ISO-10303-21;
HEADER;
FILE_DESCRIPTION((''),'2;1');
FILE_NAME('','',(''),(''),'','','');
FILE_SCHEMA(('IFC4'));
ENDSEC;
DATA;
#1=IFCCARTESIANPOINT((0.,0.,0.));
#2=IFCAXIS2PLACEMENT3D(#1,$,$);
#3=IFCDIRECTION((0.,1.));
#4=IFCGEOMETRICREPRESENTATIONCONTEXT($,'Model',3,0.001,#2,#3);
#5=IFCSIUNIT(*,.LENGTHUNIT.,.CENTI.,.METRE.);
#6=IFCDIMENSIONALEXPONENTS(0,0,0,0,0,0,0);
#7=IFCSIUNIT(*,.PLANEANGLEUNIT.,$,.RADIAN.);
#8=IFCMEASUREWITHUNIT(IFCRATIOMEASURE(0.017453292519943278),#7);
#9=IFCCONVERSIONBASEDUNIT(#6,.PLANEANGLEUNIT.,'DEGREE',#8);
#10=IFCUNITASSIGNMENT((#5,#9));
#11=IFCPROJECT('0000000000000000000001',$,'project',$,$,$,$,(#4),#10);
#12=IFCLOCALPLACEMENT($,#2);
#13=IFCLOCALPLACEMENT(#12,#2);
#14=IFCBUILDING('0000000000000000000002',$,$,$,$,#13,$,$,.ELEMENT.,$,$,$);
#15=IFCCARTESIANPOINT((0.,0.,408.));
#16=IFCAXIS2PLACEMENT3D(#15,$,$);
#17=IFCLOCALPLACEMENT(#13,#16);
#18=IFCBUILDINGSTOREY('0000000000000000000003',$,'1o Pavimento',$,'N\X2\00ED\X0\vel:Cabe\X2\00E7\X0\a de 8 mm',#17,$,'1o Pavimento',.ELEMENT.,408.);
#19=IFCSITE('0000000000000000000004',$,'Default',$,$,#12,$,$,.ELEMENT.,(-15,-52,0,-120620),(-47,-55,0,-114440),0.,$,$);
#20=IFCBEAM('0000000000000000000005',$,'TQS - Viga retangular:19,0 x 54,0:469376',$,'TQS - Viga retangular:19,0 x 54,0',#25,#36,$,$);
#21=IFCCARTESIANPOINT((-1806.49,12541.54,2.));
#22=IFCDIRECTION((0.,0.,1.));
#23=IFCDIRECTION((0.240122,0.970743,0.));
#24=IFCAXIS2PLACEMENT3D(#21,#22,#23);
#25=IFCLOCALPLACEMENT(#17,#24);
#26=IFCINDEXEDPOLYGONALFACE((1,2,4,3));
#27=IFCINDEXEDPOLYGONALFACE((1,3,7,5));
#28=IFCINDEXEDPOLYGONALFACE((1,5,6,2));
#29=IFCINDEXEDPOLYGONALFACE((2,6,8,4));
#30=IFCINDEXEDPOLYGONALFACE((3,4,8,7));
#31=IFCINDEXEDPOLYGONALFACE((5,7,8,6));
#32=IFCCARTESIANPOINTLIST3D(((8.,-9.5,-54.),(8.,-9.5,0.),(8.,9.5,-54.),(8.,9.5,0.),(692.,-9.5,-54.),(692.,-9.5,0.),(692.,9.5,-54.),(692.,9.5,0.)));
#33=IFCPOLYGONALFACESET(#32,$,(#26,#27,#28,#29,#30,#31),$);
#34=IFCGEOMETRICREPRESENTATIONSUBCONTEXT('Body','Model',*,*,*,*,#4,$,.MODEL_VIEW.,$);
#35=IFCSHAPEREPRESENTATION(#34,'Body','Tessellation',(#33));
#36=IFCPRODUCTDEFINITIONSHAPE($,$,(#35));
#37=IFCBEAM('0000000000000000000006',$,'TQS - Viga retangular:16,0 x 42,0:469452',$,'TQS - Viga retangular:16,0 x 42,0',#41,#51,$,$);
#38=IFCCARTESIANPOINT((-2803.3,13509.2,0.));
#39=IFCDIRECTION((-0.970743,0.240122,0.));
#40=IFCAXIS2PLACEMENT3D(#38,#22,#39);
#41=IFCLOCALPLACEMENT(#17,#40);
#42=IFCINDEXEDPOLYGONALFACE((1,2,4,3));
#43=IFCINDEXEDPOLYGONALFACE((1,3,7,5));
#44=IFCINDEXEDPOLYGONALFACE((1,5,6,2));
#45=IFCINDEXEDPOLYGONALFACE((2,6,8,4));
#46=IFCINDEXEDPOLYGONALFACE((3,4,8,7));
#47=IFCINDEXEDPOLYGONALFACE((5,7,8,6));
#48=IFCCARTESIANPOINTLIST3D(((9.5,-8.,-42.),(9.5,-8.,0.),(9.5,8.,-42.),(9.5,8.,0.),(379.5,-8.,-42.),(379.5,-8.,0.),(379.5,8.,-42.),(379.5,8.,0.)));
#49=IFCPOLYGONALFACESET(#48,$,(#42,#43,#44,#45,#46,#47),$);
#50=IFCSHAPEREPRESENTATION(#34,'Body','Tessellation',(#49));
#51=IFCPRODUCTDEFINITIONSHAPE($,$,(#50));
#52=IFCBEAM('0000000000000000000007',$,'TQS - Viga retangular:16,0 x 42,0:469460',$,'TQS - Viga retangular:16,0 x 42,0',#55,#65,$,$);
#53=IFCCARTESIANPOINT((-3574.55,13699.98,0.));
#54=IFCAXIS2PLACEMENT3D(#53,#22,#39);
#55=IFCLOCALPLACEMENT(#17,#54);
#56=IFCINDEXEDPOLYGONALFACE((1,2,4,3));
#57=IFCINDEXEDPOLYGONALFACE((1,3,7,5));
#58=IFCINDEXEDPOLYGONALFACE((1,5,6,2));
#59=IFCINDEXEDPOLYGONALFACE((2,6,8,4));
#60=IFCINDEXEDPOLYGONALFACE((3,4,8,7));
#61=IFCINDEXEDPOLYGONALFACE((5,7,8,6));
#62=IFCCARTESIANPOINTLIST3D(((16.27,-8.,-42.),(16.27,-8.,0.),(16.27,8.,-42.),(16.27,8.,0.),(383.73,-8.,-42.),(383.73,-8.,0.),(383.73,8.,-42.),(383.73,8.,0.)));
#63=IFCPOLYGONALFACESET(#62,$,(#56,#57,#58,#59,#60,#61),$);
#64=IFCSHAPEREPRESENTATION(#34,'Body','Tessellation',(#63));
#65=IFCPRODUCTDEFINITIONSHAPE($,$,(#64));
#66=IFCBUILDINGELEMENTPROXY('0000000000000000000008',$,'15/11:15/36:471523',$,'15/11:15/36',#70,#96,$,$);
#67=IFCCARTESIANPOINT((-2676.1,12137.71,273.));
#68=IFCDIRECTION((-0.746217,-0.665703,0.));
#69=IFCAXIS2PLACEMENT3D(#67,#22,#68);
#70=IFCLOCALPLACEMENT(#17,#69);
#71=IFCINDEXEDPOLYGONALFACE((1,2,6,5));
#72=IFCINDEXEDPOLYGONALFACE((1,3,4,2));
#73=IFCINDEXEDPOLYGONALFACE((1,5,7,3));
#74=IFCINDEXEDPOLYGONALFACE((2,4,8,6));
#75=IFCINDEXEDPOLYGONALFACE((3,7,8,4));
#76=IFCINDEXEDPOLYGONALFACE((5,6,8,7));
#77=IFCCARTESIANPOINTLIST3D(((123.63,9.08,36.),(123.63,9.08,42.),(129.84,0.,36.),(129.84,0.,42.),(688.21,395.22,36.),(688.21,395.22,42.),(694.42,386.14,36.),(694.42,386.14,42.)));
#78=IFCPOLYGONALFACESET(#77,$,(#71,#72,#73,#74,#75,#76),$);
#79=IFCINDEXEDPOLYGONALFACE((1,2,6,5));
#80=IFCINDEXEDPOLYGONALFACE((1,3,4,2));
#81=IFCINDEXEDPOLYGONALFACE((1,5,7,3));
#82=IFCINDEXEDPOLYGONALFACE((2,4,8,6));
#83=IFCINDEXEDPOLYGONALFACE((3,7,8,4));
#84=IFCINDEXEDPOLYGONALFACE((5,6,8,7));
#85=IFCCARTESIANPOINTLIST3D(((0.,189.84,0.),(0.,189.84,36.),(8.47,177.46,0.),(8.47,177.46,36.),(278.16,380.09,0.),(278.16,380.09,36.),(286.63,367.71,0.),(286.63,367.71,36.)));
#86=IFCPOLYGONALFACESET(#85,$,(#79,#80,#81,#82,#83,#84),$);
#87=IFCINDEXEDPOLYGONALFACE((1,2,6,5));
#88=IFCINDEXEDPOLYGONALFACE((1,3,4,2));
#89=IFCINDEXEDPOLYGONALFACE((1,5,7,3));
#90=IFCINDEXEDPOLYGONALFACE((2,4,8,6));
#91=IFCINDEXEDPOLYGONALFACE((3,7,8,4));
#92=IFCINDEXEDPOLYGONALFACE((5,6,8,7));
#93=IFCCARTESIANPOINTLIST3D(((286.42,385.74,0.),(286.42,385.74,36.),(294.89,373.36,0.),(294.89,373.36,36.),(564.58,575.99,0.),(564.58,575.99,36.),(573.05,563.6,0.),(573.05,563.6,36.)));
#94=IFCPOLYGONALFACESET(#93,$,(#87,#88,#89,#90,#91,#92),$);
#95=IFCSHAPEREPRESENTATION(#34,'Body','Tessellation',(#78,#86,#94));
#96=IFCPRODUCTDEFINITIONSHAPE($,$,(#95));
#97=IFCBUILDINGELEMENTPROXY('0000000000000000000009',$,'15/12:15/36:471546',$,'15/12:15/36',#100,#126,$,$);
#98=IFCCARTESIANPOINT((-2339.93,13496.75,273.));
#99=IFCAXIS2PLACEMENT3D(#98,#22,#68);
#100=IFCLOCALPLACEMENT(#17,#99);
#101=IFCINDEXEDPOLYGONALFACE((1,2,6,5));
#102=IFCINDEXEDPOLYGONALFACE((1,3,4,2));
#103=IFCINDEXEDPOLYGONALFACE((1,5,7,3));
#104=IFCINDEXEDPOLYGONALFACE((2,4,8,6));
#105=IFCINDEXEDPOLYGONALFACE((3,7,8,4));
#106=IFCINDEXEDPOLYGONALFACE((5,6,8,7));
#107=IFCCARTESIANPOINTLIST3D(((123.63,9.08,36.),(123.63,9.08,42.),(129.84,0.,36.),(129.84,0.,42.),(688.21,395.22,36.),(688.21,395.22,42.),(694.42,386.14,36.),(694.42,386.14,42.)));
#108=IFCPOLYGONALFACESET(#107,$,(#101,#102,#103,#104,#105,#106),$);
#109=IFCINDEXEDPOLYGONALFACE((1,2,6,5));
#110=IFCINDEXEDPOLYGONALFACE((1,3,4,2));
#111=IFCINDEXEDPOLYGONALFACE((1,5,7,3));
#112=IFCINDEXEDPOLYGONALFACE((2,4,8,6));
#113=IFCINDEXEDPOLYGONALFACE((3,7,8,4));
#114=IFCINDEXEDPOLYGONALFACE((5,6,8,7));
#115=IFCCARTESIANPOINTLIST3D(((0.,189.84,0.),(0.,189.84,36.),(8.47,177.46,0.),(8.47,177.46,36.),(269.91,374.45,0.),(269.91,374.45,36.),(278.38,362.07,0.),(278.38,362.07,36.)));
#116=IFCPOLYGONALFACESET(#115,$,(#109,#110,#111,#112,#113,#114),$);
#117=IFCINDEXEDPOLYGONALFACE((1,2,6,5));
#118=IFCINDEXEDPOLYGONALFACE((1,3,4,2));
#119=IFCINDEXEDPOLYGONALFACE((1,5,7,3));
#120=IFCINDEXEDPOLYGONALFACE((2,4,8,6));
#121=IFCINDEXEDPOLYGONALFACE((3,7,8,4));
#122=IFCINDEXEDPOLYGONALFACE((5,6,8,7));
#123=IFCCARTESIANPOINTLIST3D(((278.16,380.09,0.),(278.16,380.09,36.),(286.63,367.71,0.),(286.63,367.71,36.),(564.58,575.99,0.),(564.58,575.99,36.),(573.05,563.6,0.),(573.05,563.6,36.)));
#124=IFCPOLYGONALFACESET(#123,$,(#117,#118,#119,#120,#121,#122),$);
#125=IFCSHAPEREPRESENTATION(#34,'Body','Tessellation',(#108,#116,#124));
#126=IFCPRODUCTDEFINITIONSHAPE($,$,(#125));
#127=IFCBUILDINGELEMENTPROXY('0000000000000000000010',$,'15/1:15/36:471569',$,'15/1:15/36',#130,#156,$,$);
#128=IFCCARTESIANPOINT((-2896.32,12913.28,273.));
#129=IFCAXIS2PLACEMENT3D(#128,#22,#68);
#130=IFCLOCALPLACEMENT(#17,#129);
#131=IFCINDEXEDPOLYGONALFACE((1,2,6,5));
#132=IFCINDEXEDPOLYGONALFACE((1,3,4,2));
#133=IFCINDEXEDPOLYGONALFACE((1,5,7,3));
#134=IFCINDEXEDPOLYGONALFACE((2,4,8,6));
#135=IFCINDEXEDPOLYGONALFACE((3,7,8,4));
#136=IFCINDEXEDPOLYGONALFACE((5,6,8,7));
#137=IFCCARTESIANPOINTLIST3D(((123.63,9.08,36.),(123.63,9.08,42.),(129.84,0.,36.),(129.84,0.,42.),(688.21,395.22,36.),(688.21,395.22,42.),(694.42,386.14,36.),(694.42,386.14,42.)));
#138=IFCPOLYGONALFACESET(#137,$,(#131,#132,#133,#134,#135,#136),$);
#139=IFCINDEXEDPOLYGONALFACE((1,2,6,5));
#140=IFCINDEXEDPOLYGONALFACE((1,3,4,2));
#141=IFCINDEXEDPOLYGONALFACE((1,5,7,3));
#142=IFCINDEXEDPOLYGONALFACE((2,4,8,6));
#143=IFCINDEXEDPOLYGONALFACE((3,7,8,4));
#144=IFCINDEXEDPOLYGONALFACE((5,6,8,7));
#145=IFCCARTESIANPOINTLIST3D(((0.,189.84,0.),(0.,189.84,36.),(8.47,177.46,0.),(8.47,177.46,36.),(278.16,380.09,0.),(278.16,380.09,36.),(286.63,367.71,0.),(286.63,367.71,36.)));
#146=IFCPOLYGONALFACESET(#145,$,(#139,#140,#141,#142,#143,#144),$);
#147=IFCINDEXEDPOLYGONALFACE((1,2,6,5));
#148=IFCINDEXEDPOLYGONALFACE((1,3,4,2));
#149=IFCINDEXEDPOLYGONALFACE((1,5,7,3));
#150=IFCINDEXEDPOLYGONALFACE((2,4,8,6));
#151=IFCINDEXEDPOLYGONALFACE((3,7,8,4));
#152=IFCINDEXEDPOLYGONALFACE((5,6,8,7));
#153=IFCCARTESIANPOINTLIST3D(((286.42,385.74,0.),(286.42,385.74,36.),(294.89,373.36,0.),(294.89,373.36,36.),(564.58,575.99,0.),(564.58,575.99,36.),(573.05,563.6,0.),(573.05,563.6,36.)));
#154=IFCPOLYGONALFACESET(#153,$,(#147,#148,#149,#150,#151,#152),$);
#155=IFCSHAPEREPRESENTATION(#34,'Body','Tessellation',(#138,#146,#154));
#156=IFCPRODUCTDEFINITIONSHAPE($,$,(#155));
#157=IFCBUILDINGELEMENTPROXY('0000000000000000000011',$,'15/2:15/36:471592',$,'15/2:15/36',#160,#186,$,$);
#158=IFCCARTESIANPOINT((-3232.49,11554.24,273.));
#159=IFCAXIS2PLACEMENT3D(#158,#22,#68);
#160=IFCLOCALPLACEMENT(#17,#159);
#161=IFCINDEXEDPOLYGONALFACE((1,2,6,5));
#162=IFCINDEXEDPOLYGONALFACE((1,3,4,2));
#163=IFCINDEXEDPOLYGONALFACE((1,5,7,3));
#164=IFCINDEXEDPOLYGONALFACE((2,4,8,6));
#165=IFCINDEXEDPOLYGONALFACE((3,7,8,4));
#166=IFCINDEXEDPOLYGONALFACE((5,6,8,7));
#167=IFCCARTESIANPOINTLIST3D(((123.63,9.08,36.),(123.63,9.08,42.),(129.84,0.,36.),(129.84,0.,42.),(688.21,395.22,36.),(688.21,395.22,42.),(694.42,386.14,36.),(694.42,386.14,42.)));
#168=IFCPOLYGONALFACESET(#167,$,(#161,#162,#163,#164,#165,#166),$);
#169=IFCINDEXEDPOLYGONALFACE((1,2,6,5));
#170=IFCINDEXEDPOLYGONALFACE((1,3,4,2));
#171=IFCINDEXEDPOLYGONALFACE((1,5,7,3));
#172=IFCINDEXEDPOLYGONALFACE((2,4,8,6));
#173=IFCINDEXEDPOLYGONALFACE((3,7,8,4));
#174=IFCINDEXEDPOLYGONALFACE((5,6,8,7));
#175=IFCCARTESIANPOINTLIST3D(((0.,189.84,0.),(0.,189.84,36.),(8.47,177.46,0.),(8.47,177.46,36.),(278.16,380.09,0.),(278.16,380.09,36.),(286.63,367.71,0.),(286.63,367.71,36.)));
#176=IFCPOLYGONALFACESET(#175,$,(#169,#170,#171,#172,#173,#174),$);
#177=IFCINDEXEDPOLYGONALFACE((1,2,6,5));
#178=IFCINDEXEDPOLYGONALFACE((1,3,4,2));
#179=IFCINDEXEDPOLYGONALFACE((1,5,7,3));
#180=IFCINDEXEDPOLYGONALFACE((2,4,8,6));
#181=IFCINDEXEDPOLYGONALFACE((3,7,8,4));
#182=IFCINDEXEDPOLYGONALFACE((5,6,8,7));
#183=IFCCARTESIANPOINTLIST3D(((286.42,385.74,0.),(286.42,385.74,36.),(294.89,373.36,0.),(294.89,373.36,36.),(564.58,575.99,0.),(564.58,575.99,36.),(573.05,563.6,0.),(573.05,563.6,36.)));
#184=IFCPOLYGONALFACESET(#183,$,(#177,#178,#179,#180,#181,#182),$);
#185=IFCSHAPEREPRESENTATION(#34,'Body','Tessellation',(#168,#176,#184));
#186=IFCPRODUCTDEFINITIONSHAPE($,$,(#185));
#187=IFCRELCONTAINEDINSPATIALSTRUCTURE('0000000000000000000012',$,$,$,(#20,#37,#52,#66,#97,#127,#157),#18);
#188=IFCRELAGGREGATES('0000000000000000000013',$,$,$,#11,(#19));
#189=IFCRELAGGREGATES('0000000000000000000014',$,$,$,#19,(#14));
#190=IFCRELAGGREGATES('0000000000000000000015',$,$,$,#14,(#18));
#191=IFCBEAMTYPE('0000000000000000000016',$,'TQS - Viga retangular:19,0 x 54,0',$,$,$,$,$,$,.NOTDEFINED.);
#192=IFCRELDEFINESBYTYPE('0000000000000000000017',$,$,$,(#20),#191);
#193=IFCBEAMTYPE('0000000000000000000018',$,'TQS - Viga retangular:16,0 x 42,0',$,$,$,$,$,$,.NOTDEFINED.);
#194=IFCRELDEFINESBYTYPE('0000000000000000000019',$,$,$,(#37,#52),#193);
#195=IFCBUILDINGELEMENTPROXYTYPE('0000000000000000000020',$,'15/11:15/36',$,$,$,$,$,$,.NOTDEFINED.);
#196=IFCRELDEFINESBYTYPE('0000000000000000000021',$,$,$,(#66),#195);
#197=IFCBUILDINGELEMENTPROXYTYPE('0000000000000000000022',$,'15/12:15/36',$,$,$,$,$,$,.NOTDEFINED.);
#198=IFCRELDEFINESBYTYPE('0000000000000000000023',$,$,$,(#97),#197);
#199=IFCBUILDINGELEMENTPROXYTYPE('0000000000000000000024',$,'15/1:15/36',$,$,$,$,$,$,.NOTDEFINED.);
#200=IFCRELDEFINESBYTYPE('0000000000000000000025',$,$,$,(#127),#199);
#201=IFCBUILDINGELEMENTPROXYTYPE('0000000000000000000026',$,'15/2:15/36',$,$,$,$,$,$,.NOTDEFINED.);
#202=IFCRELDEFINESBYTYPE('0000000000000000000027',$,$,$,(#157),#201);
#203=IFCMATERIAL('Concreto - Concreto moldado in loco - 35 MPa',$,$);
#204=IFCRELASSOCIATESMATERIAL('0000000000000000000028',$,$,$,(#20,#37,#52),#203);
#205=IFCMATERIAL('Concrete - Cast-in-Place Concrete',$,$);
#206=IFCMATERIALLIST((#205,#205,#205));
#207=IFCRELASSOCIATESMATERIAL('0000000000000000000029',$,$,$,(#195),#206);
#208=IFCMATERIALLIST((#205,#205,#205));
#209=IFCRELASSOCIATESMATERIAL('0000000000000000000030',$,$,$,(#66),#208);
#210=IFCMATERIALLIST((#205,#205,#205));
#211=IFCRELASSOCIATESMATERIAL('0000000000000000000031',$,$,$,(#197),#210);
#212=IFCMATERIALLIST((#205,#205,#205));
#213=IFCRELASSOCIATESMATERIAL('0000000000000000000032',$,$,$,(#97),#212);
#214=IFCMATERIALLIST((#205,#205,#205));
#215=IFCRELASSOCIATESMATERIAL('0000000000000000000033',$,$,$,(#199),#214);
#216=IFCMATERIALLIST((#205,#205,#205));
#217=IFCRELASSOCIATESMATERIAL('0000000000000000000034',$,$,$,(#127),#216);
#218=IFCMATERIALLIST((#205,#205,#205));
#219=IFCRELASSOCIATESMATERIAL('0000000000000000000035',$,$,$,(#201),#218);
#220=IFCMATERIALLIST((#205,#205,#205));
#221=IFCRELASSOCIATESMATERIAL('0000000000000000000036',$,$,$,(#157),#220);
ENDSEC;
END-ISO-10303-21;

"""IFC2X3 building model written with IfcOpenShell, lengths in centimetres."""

from ifc_helpers import new_model, entity, si_unit, converted_unit, direction, frame, frame_2d, origin, place, context, subcontext, project, spatial, rectangle, extrude, source, transform, mapped, material, material_list, type_object, type_shapes, element, save


model = new_model("IFC2X3")

# Units and contexts
model_context = context("Model", 3, precision=0.001, world=origin(), true_north=direction((0.0, 1.0)))
body_context = subcontext(model_context, "Body", "Model", "MODEL_VIEW")
ifc_project = project(units=[si_unit("LENGTHUNIT", "METRE", prefix="CENTI"), converted_unit("PLANEANGLEUNIT", "DEGREE", entity("IfcRatioMeasure", 0.017453292519943278), si_unit("PLANEANGLEUNIT", "RADIAN"), dimensions=[0, 0, 0, 0, 0, 0, 0])], contexts=[model_context])

# Site, building, storey
site_placement = place(None, origin())
site = spatial("IfcSite", under=ifc_project, at=site_placement, Name="Default", CompositionType="ELEMENT", RefLatitude=(-15, -52, 0, -120620), RefLongitude=(-47, -55, 0, -114440), RefElevation=0.0)
building_placement = place(site_placement, origin())
building = spatial("IfcBuilding", under=site, at=building_placement, CompositionType="ELEMENT")
storey_placement = place(building_placement, frame((0.0, 0.0, 408.0)))
storey = spatial("IfcBuildingStorey", under=building, at=storey_placement, Name="1o Pavimento", ObjectType="Nível:Cabeça de 8 mm", LongName="1o Pavimento", CompositionType="ELEMENT", Elevation=408.0)

# Beams
ifc_material_1 = material(Name="Concreto - Concreto moldado in loco - 35 MPa")
beam_type_1 = type_object("IfcBeamType", Name="TQS - Viga retangular:19,0 x 54,0", PredefinedType="NOTDEFINED")
beam_1_placement = place(storey_placement, frame((-1806.49, 12541.54, 2.0), z_axis=(0.0, 0.0, 1.0), x_axis=(0.240122, 0.970743, 0.0)))
element("IfcBeam", 1, at=beam_1_placement, inside=storey, type_object=beam_type_1, material=ifc_material_1, Name="TQS - Viga retangular:19,0 x 54,0:469376", ObjectType="TQS - Viga retangular:19,0 x 54,0", context=body_context, shape_type="SweptSolid", body=[
    extrude(rectangle(XDim=54.0, YDim=19.0, at=frame_2d((0.0, 0.0), x_axis=(1.0, 0.0))), frame((8.0, 0.0, -27.0), z_axis=(1.0, 0.0, 0.0), x_axis=(0.0, 0.0, -1.0)), (0.0, 0.0, 1.0), 684.0),
])
beam_type_2 = type_object("IfcBeamType", Name="TQS - Viga retangular:16,0 x 42,0", PredefinedType="NOTDEFINED")
beam_2_placement = place(storey_placement, frame((-2803.3, 13509.2, 0.0), z_axis=(0.0, 0.0, 1.0), x_axis=(-0.970743, 0.240122, 0.0)))
element("IfcBeam", 2, at=beam_2_placement, inside=storey, type_object=beam_type_2, material=ifc_material_1, Name="TQS - Viga retangular:16,0 x 42,0:469452", ObjectType="TQS - Viga retangular:16,0 x 42,0", context=body_context, shape_type="SweptSolid", body=[
    extrude(rectangle(XDim=42.0, YDim=16.0, at=frame_2d((0.0, 0.0), x_axis=(1.0, 0.0))), frame((9.5, 0.0, -21.0), z_axis=(1.0, 0.0, 0.0), x_axis=(0.0, 0.0, -1.0)), (0.0, 0.0, 1.0), 370.0),
])
beam_3_placement = place(storey_placement, frame((-3574.55, 13699.98, 0.0), z_axis=(0.0, 0.0, 1.0), x_axis=(-0.970743, 0.240122, 0.0)))
element("IfcBeam", 3, at=beam_3_placement, inside=storey, type_object=beam_type_2, material=ifc_material_1, Name="TQS - Viga retangular:16,0 x 42,0:469460", ObjectType="TQS - Viga retangular:16,0 x 42,0", context=body_context, shape_type="SweptSolid", body=[
    extrude(rectangle(XDim=42.0, YDim=16.0, at=frame_2d((0.0, 0.0), x_axis=(1.0, 0.0))), frame((16.27, 0.0, -21.0), z_axis=(1.0, 0.0, 0.0), x_axis=(0.0, 0.0, -1.0)), (0.0, 0.0, 1.0), 367.46),
])

# Building element proxies
ifc_material_2 = material(Name="Concrete - Cast-in-Place Concrete")
ifc_material_list_1 = material_list([ifc_material_2, ifc_material_2, ifc_material_2])
ifc_material_list_2 = material_list([ifc_material_2, ifc_material_2, ifc_material_2])
building_element_proxy_type_1 = type_object("IfcBuildingElementProxyType", Name="15/11:15/36", PredefinedType="NOTDEFINED", material=ifc_material_list_2)
shared_shape_1 = source(origin(), body_context, "Body", "SweptSolid", [
    extrude(rectangle(XDim=11.0, YDim=684.0, at=frame_2d((0.0, 0.0), x_axis=(1.0, 0.0))), frame((409.03, 197.61, 36.0), z_axis=(0.0, 0.0, 1.0), x_axis=(-0.564535, 0.825409, 0.0)), (0.0, 0.0, 1.0), 6.0),
    extrude(rectangle(XDim=337.0, YDim=15.0, at=frame_2d((0.0, 0.0), x_axis=(1.0, 0.0))), frame((143.32, 278.78, 0.0), z_axis=(0.0, 0.0, 1.0), x_axis=(0.825409, 0.564535, 0.0)), (0.0, 0.0, 1.0), 36.0),
    extrude(rectangle(XDim=337.0, YDim=15.0, at=frame_2d((0.0, 0.0), x_axis=(1.0, 0.0))), frame((429.73, 474.67, 0.0), z_axis=(0.0, 0.0, 1.0), x_axis=(0.825409, 0.564535, 0.0)), (0.0, 0.0, 1.0), 36.0),
])
type_shapes(building_element_proxy_type_1, [shared_shape_1])
proxy_1_placement = place(storey_placement, frame((-2676.1, 12137.71, 273.0), z_axis=(0.0, 0.0, 1.0), x_axis=(-0.746217, -0.665703, 0.0)))
element("IfcBuildingElementProxy", 4, at=proxy_1_placement, inside=storey, type_object=building_element_proxy_type_1, material=ifc_material_list_1, Name="15/11:15/36:471523", ObjectType="15/11:15/36", context=body_context, shape_type="MappedRepresentation", body=[
    mapped(shared_shape_1, transform((0.0, 0.0, 0.0), scale=1.0)),
])
ifc_material_list_3 = material_list([ifc_material_2, ifc_material_2, ifc_material_2])
ifc_material_list_4 = material_list([ifc_material_2, ifc_material_2, ifc_material_2])
building_element_proxy_type_2 = type_object("IfcBuildingElementProxyType", Name="15/12:15/36", PredefinedType="NOTDEFINED", material=ifc_material_list_4)
shared_shape_2 = source(origin(), body_context, "Body", "SweptSolid", [
    extrude(rectangle(XDim=11.0, YDim=684.0, at=frame_2d((0.0, 0.0), x_axis=(1.0, 0.0))), frame((409.03, 197.61, 36.0), z_axis=(0.0, 0.0, 1.0), x_axis=(-0.564535, 0.825409, 0.0)), (0.0, 0.0, 1.0), 6.0),
    extrude(rectangle(XDim=327.0, YDim=15.0, at=frame_2d((0.0, 0.0), x_axis=(1.0, 0.0))), frame((139.19, 275.96, 0.0), z_axis=(0.0, 0.0, 1.0), x_axis=(0.825409, 0.564535, 0.0)), (0.0, 0.0, 1.0), 36.0),
    extrude(rectangle(XDim=347.0, YDim=15.0, at=frame_2d((0.0, 0.0), x_axis=(1.0, 0.0))), frame((425.61, 471.85, 0.0), z_axis=(0.0, 0.0, 1.0), x_axis=(0.825409, 0.564535, 0.0)), (0.0, 0.0, 1.0), 36.0),
])
type_shapes(building_element_proxy_type_2, [shared_shape_2])
proxy_2_placement = place(storey_placement, frame((-2339.93, 13496.75, 273.0), z_axis=(0.0, 0.0, 1.0), x_axis=(-0.746217, -0.665703, 0.0)))
element("IfcBuildingElementProxy", 5, at=proxy_2_placement, inside=storey, type_object=building_element_proxy_type_2, material=ifc_material_list_3, Name="15/12:15/36:471546", ObjectType="15/12:15/36", context=body_context, shape_type="MappedRepresentation", body=[
    mapped(shared_shape_2, transform((0.0, 0.0, 0.0), scale=1.0)),
])
ifc_material_list_5 = material_list([ifc_material_2, ifc_material_2, ifc_material_2])
ifc_material_list_6 = material_list([ifc_material_2, ifc_material_2, ifc_material_2])
building_element_proxy_type_3 = type_object("IfcBuildingElementProxyType", Name="15/1:15/36", PredefinedType="NOTDEFINED", material=ifc_material_list_6)
shared_shape_3 = source(origin(), body_context, "Body", "SweptSolid", [
    extrude(rectangle(XDim=11.0, YDim=684.0, at=frame_2d((0.0, 0.0), x_axis=(1.0, 0.0))), frame((409.03, 197.61, 36.0), z_axis=(0.0, 0.0, 1.0), x_axis=(-0.564535, 0.825409, 0.0)), (0.0, 0.0, 1.0), 6.0),
    extrude(rectangle(XDim=337.0, YDim=15.0, at=frame_2d((0.0, 0.0), x_axis=(1.0, 0.0))), frame((143.32, 278.78, 0.0), z_axis=(0.0, 0.0, 1.0), x_axis=(0.825409, 0.564535, 0.0)), (0.0, 0.0, 1.0), 36.0),
    extrude(rectangle(XDim=337.0, YDim=15.0, at=frame_2d((0.0, 0.0), x_axis=(1.0, 0.0))), frame((429.73, 474.67, 0.0), z_axis=(0.0, 0.0, 1.0), x_axis=(0.825409, 0.564535, 0.0)), (0.0, 0.0, 1.0), 36.0),
])
type_shapes(building_element_proxy_type_3, [shared_shape_3])
proxy_3_placement = place(storey_placement, frame((-2896.32, 12913.28, 273.0), z_axis=(0.0, 0.0, 1.0), x_axis=(-0.746217, -0.665703, 0.0)))
element("IfcBuildingElementProxy", 6, at=proxy_3_placement, inside=storey, type_object=building_element_proxy_type_3, material=ifc_material_list_5, Name="15/1:15/36:471569", ObjectType="15/1:15/36", context=body_context, shape_type="MappedRepresentation", body=[
    mapped(shared_shape_3, transform((0.0, 0.0, 0.0), scale=1.0)),
])
ifc_material_list_7 = material_list([ifc_material_2, ifc_material_2, ifc_material_2])
ifc_material_list_8 = material_list([ifc_material_2, ifc_material_2, ifc_material_2])
building_element_proxy_type_4 = type_object("IfcBuildingElementProxyType", Name="15/2:15/36", PredefinedType="NOTDEFINED", material=ifc_material_list_8)
shared_shape_4 = source(origin(), body_context, "Body", "SweptSolid", [
    extrude(rectangle(XDim=11.0, YDim=684.0, at=frame_2d((0.0, 0.0), x_axis=(1.0, 0.0))), frame((409.03, 197.61, 36.0), z_axis=(0.0, 0.0, 1.0), x_axis=(-0.564535, 0.825409, 0.0)), (0.0, 0.0, 1.0), 6.0),
    extrude(rectangle(XDim=337.0, YDim=15.0, at=frame_2d((0.0, 0.0), x_axis=(1.0, 0.0))), frame((143.32, 278.78, 0.0), z_axis=(0.0, 0.0, 1.0), x_axis=(0.825409, 0.564535, 0.0)), (0.0, 0.0, 1.0), 36.0),
    extrude(rectangle(XDim=337.0, YDim=15.0, at=frame_2d((0.0, 0.0), x_axis=(1.0, 0.0))), frame((429.73, 474.67, 0.0), z_axis=(0.0, 0.0, 1.0), x_axis=(0.825409, 0.564535, 0.0)), (0.0, 0.0, 1.0), 36.0),
])
type_shapes(building_element_proxy_type_4, [shared_shape_4])
proxy_4_placement = place(storey_placement, frame((-3232.49, 11554.24, 273.0), z_axis=(0.0, 0.0, 1.0), x_axis=(-0.746217, -0.665703, 0.0)))
element("IfcBuildingElementProxy", 7, at=proxy_4_placement, inside=storey, type_object=building_element_proxy_type_4, material=ifc_material_list_7, Name="15/2:15/36:471592", ObjectType="15/2:15/36", context=body_context, shape_type="MappedRepresentation", body=[
    mapped(shared_shape_4, transform((0.0, 0.0, 0.0), scale=1.0)),
])

save(model, "model.ifc")
